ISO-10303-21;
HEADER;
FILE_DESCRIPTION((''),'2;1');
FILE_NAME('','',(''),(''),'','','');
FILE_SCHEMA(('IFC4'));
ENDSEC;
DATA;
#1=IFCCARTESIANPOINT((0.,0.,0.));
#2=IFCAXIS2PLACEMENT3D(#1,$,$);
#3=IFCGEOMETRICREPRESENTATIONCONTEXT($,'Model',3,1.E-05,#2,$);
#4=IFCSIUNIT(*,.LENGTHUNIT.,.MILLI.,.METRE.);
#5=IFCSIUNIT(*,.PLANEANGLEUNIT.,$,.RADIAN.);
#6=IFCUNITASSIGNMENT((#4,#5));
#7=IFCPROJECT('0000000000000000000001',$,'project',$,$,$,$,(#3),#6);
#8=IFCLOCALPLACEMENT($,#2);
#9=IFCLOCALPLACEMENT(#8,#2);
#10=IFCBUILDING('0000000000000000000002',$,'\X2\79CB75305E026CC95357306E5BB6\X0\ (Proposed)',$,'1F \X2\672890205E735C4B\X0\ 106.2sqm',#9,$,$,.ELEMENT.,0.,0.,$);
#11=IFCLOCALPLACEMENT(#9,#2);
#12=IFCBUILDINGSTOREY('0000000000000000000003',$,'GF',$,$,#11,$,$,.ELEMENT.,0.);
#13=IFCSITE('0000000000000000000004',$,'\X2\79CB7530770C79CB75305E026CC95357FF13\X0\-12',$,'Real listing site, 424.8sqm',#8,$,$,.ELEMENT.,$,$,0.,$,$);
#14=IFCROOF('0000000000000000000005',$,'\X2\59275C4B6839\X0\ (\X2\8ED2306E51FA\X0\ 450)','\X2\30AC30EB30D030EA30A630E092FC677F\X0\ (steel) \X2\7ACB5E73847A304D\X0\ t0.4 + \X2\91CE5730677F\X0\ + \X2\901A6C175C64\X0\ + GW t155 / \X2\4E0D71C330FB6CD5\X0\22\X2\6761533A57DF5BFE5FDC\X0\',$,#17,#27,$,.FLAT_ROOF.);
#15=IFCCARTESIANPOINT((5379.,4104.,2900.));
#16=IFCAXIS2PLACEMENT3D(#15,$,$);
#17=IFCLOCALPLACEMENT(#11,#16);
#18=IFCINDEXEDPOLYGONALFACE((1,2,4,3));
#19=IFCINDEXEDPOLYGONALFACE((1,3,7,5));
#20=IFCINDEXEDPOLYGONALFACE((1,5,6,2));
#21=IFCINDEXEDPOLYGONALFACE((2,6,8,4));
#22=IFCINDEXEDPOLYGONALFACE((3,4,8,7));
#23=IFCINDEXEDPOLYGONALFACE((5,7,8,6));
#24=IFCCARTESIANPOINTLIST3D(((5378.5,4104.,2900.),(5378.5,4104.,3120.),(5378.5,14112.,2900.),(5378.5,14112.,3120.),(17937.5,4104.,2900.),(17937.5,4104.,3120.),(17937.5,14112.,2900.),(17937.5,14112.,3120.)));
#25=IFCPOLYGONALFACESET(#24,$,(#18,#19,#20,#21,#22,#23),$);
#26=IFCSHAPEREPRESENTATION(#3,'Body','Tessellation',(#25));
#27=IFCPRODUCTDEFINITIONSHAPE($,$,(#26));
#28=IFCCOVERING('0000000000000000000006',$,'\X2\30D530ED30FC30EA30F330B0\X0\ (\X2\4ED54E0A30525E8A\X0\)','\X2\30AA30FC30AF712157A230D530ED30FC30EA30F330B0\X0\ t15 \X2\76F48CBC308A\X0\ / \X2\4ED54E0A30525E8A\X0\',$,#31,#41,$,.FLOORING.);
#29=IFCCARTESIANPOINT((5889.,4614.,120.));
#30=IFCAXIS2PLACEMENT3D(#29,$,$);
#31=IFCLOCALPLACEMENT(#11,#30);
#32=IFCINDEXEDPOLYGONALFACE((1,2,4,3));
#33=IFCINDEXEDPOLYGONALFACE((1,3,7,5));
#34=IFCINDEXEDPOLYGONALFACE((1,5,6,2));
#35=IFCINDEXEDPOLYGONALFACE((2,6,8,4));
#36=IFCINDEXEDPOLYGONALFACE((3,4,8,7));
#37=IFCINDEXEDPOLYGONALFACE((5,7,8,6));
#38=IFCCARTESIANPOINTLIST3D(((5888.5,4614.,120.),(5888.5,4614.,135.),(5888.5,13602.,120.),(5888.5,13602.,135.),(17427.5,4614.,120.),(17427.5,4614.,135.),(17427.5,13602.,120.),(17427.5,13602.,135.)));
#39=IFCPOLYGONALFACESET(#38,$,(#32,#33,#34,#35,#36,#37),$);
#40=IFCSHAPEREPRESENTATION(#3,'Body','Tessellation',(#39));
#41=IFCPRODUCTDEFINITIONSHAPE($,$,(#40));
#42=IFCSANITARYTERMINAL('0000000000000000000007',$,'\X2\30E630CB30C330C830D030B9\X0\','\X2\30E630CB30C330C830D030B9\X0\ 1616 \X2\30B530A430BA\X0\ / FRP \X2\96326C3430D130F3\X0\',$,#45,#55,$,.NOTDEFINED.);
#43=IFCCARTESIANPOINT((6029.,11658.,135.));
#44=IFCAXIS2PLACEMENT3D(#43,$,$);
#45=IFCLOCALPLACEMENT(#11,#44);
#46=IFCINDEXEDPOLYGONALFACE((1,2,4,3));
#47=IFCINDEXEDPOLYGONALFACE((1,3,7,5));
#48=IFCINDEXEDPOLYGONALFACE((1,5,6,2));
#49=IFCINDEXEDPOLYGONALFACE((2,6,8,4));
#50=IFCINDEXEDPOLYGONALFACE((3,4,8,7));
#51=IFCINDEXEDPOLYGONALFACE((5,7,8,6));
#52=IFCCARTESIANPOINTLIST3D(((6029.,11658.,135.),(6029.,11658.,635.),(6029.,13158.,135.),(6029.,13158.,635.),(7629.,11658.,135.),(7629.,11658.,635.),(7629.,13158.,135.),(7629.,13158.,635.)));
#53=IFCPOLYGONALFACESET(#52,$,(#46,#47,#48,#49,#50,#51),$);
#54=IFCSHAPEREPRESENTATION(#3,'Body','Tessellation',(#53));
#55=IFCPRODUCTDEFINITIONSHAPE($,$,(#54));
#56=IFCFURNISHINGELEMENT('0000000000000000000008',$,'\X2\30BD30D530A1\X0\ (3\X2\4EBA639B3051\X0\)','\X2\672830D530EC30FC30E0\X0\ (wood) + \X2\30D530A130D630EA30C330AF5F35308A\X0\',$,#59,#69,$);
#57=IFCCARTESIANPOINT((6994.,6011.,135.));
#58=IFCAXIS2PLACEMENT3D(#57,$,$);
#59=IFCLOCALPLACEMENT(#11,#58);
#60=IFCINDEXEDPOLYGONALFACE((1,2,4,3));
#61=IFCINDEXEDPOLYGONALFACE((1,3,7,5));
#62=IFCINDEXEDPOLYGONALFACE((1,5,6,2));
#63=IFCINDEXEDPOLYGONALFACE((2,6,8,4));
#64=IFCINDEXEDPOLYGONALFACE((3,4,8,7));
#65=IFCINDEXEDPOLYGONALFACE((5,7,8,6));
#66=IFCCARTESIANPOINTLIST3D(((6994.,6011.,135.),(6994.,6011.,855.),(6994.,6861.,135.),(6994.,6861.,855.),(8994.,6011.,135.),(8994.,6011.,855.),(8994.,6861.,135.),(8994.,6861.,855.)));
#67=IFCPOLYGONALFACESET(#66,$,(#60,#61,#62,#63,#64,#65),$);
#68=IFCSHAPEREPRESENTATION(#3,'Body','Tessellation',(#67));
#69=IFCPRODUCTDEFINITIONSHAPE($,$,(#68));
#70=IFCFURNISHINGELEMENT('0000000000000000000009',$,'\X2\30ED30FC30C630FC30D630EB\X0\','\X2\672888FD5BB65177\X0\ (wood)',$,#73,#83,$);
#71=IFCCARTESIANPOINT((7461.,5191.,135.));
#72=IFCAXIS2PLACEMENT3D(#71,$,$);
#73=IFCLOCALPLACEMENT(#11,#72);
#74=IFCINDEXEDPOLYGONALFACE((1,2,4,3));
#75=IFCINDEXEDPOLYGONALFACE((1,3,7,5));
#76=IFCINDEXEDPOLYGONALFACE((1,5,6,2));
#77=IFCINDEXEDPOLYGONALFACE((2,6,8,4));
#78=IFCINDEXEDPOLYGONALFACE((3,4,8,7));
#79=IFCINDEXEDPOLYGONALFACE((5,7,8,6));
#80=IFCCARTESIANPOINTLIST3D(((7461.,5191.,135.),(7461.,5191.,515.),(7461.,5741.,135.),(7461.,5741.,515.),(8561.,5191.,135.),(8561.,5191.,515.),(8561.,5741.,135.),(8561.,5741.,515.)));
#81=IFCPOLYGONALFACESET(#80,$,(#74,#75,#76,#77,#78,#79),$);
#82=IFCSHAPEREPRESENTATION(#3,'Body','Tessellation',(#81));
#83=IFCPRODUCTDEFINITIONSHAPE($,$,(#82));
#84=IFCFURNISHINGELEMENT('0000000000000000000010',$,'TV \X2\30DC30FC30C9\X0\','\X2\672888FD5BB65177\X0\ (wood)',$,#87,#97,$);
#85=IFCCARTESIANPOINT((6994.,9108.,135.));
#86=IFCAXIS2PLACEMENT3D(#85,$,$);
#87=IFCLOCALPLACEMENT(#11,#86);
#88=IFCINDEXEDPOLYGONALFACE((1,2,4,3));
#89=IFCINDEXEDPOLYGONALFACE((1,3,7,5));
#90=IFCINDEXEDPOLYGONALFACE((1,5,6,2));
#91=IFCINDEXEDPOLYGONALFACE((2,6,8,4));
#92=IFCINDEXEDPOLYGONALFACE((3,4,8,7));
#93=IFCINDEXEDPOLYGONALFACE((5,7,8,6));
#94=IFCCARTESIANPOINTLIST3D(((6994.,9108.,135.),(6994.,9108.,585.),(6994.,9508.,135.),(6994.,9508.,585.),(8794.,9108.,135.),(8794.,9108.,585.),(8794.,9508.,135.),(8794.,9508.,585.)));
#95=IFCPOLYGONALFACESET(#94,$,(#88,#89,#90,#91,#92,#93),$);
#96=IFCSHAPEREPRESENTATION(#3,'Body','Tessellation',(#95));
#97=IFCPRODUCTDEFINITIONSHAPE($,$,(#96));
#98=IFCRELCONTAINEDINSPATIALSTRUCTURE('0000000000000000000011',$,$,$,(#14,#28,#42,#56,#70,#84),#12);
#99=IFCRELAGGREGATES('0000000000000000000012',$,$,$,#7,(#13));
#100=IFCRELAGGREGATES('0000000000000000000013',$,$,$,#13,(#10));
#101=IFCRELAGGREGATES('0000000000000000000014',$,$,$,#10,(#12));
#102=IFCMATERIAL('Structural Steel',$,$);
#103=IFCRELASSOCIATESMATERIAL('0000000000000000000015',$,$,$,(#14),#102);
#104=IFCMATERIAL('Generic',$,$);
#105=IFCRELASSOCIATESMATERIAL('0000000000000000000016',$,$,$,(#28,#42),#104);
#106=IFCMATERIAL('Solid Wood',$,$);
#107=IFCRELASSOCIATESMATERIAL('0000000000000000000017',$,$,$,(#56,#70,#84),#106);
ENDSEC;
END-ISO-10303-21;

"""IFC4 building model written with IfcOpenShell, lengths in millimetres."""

from ifc_helpers import new_model, si_unit, frame, frame_2d, origin, place, context, project, spatial, rectangle, extrude, material, element, save


model = new_model("IFC4")

# Units and contexts
model_context = context("Model", 3, precision=1e-05, world=origin())
ifc_project = project(units=[si_unit("LENGTHUNIT", "METRE", prefix="MILLI"), si_unit("PLANEANGLEUNIT", "RADIAN")], contexts=[model_context])

# Site, building, storey
site_placement = place(None, origin())
site = spatial("IfcSite", under=ifc_project, at=site_placement, Name="秋田県秋田市泉南３-12", ObjectType="Real listing site, 424.8sqm", CompositionType="ELEMENT", RefElevation=0.0)
building_placement = place(site_placement, origin())
building = spatial("IfcBuilding", under=site, at=building_placement, Name="秋田市泉南の家 (Proposed)", ObjectType="1F 木造平屋 106.2sqm", CompositionType="ELEMENT", ElevationOfRefHeight=0.0, ElevationOfTerrain=0.0)
storey_placement = place(building_placement, origin())
storey = spatial("IfcBuildingStorey", under=building, at=storey_placement, Name="GF", CompositionType="ELEMENT", Elevation=0.0)

# Shared definitions
ifc_material_1 = material(Name="Solid Wood")

# Roof
ifc_material_2 = material(Name="Structural Steel")
roof_placement = place(storey_placement, frame((5379.0, 4104.0, 2900.0)))
element("IfcRoof", 1, at=roof_placement, inside=storey, material=ifc_material_2, Name="大屋根 (軒の出 450)", Description="ガルバリウム鋼板 (steel) 立平葺き t0.4 + 野地板 + 通気層 + GW t155 / 不燃・法22条区域対応", PredefinedType="FLAT_ROOF", context=model_context, shape_type="SweptSolid", body=[
    extrude(rectangle(XDim=12559.0, YDim=10008.0, at=frame_2d((6279.0, 5004.0))), frame((5379.0, 4104.0, 2900.0)), (0.0, 0.0, 1.0), 220.0),
])

# Covering
ifc_material_3 = material(Name="Generic")
covering_placement = place(storey_placement, frame((5889.0, 4614.0, 120.0)))
element("IfcCovering", 2, at=covering_placement, inside=storey, material=ifc_material_3, Name="フローリング (仕上げ床)", Description="オーク無垢フローリング t15 直貼り / 仕上げ床", PredefinedType="FLOORING", context=model_context, shape_type="SweptSolid", body=[
    extrude(rectangle(XDim=11539.0, YDim=8988.0, at=frame_2d((5769.0, 4494.0))), frame((5889.0, 4614.0, 120.0)), (0.0, 0.0, 1.0), 15.0),
])

# Sanitary terminal
sanitary_terminal_placement = place(storey_placement, frame((6029.0, 11658.0, 135.0)))
element("IfcSanitaryTerminal", 3, at=sanitary_terminal_placement, inside=storey, material=ifc_material_3, Name="ユニットバス", Description="ユニットバス 1616 サイズ / FRP 防水パン", PredefinedType="NOTDEFINED", context=model_context, shape_type="SweptSolid", body=[
    extrude(rectangle(XDim=1600.0, YDim=1500.0, at=frame_2d((800.0, 750.0))), frame((6029.0, 11658.0, 135.0)), (0.0, 0.0, 1.0), 500.0),
])

# Furnishing elements
furnishing_1_placement = place(storey_placement, frame((6994.0, 6011.0, 135.0)))
element("IfcFurnishingElement", 4, at=furnishing_1_placement, inside=storey, material=ifc_material_1, Name="ソファ (3人掛け)", Description="木フレーム (wood) + ファブリック張り", context=model_context, shape_type="SweptSolid", body=[
    extrude(rectangle(XDim=2000.0, YDim=850.0, at=frame_2d((1000.0, 425.0))), frame((6994.0, 6011.0, 135.0)), (0.0, 0.0, 1.0), 720.0),
])
furnishing_2_placement = place(storey_placement, frame((7461.0, 5191.0, 135.0)))
element("IfcFurnishingElement", 5, at=furnishing_2_placement, inside=storey, material=ifc_material_1, Name="ローテーブル", Description="木製家具 (wood)", context=model_context, shape_type="SweptSolid", body=[
    extrude(rectangle(XDim=1100.0, YDim=550.0, at=frame_2d((550.0, 275.0))), frame((7461.0, 5191.0, 135.0)), (0.0, 0.0, 1.0), 380.0),
])
furnishing_3_placement = place(storey_placement, frame((6994.0, 9108.0, 135.0)))
element("IfcFurnishingElement", 6, at=furnishing_3_placement, inside=storey, material=ifc_material_1, Name="TV ボード", Description="木製家具 (wood)", context=model_context, shape_type="SweptSolid", body=[
    extrude(rectangle(XDim=1800.0, YDim=400.0, at=frame_2d((900.0, 200.0))), frame((6994.0, 9108.0, 135.0)), (0.0, 0.0, 1.0), 450.0),
])

save(model, "model.ifc")
